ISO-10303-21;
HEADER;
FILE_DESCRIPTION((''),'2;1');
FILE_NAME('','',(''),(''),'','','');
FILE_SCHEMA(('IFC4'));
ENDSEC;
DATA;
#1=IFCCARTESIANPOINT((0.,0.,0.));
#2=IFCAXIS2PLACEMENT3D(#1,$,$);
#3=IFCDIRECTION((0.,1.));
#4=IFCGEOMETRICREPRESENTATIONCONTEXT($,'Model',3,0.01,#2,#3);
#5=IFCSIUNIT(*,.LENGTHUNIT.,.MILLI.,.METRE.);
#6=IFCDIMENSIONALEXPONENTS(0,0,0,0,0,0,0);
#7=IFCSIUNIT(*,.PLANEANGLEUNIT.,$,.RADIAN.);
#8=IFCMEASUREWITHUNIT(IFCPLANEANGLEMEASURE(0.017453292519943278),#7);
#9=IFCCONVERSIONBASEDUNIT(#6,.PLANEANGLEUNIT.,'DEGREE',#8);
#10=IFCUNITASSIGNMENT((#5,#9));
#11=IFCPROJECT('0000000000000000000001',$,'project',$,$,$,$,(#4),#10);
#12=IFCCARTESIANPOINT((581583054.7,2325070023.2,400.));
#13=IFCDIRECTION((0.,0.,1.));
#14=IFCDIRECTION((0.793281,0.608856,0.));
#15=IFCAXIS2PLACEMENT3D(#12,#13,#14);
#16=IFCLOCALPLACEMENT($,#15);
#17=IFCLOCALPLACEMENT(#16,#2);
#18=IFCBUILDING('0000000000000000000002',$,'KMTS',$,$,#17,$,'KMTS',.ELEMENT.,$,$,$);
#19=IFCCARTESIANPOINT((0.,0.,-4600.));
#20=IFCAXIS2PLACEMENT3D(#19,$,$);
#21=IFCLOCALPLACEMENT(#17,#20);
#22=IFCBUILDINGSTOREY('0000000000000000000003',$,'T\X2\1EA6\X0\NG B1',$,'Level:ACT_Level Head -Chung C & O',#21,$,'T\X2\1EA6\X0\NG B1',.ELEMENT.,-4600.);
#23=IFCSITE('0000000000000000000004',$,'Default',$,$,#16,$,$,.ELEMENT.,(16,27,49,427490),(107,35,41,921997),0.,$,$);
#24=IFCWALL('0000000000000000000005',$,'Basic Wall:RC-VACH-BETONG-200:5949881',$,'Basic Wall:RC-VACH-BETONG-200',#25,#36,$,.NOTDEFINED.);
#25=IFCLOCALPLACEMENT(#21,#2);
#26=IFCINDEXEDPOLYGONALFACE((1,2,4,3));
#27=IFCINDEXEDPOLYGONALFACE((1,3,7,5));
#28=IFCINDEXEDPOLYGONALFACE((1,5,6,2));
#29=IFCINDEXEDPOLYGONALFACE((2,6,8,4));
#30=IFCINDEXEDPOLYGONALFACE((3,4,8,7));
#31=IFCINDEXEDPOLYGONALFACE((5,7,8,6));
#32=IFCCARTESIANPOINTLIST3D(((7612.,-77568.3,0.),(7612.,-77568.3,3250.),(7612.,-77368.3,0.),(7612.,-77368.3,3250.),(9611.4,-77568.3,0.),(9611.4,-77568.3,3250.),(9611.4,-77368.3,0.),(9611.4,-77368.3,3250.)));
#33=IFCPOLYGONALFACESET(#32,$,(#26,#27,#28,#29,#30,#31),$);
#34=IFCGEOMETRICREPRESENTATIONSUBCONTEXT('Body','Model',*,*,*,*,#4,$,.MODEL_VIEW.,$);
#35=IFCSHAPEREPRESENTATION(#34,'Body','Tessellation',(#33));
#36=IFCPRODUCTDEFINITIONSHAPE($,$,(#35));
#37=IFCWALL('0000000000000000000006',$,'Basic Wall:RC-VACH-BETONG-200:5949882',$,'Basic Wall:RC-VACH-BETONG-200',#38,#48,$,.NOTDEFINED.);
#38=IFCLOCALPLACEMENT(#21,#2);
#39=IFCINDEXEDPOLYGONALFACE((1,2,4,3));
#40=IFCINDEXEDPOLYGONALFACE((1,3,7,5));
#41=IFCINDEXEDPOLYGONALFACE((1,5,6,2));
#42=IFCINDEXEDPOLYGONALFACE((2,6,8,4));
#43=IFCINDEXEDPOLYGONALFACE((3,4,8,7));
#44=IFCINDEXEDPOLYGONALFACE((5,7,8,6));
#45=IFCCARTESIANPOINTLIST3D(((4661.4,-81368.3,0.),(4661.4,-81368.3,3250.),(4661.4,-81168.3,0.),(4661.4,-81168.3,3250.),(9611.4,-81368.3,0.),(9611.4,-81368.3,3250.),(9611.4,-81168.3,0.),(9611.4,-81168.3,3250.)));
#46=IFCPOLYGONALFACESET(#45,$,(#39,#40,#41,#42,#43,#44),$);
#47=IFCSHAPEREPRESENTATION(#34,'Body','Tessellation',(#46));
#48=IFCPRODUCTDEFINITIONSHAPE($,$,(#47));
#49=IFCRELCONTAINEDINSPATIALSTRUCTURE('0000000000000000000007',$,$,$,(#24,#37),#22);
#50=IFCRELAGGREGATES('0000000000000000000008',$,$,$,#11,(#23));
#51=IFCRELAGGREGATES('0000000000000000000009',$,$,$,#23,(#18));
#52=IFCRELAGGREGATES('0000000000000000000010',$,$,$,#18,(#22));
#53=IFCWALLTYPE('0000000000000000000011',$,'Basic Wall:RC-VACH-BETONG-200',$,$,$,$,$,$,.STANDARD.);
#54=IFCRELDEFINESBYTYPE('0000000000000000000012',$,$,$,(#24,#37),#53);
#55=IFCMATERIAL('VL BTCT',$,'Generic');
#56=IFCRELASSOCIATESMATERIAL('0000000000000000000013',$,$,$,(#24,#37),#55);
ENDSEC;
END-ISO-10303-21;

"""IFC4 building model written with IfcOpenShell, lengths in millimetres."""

from ifc_helpers import new_model, entity, si_unit, converted_unit, direction, frame, origin, place, context, subcontext, project, spatial, indexed_curve, outline, extrude, material, type_object, element, save


model = new_model("IFC4")

# Units and contexts
model_context = context("Model", 3, precision=0.01, world=origin(), true_north=direction((0.0, 1.0)))
body_context = subcontext(model_context, "Body", "Model", "MODEL_VIEW")
ifc_project = project(units=[si_unit("LENGTHUNIT", "METRE", prefix="MILLI"), converted_unit("PLANEANGLEUNIT", "DEGREE", entity("IfcPlaneAngleMeasure", 0.017453292519943278), si_unit("PLANEANGLEUNIT", "RADIAN"), dimensions=[0, 0, 0, 0, 0, 0, 0])], contexts=[model_context])

# Site, building, storey
site_placement = place(None, frame((581583054.7, 2325070023.2, 400.0), z_axis=(0.0, 0.0, 1.0), x_axis=(0.793281, 0.608856, 0.0)))
site = spatial("IfcSite", under=ifc_project, at=site_placement, Name="Default", CompositionType="ELEMENT", RefLatitude=(16, 27, 49, 427490), RefLongitude=(107, 35, 41, 921997), RefElevation=0.0)
building_placement = place(site_placement, origin())
building = spatial("IfcBuilding", under=site, at=building_placement, Name="KMTS", LongName="KMTS", CompositionType="ELEMENT")
storey_placement = place(building_placement, frame((0.0, 0.0, -4600.0)))
storey = spatial("IfcBuildingStorey", under=building, at=storey_placement, Name="TẦNG B1", ObjectType="Level:ACT_Level Head -Chung C & O", LongName="TẦNG B1", CompositionType="ELEMENT", Elevation=-4600.0)

# Shared definitions
ifc_material_1 = material(Name="VL BTCT", Category="Generic")

# Walls
wall_type_1 = type_object("IfcWallType", Name="Basic Wall:RC-VACH-BETONG-200", PredefinedType="STANDARD")
wall_1_placement = place(storey_placement, frame((9611.4, -77468.3, 0.0), z_axis=(0.0, 0.0, 1.0), x_axis=(-1.0, 0.0, 0.0)))
element("IfcWall", 1, at=wall_1_placement, inside=storey, type_object=wall_type_1, material=ifc_material_1, Name="Basic Wall:RC-VACH-BETONG-200:5949881", ObjectType="Basic Wall:RC-VACH-BETONG-200", PredefinedType="NOTDEFINED", context=body_context, shape_type="SweptSolid", body=[
    extrude(outline(indexed_curve([(1999.4, 100.0), (0.0, 100.0), (0.0, -100.0), (1999.4, -100.0), (1999.4, 100.0)], self_intersect=False)), origin(), (0.0, 0.0, 1.0), 3250.0),
])
wall_2_placement = place(storey_placement, frame((9611.4, -81268.3, 0.0), z_axis=(0.0, 0.0, 1.0), x_axis=(-1.0, 0.0, 0.0)))
element("IfcWall", 2, at=wall_2_placement, inside=storey, type_object=wall_type_1, material=ifc_material_1, Name="Basic Wall:RC-VACH-BETONG-200:5949882", ObjectType="Basic Wall:RC-VACH-BETONG-200", PredefinedType="NOTDEFINED", context=body_context, shape_type="SweptSolid", body=[
    extrude(outline(indexed_curve([(4950.0, 100.0), (0.0, 100.0), (0.0, -100.0), (4950.0, -100.0), (4950.0, 100.0)], self_intersect=False)), origin(), (0.0, 0.0, 1.0), 3250.0),
])

save(model, "model.ifc")
